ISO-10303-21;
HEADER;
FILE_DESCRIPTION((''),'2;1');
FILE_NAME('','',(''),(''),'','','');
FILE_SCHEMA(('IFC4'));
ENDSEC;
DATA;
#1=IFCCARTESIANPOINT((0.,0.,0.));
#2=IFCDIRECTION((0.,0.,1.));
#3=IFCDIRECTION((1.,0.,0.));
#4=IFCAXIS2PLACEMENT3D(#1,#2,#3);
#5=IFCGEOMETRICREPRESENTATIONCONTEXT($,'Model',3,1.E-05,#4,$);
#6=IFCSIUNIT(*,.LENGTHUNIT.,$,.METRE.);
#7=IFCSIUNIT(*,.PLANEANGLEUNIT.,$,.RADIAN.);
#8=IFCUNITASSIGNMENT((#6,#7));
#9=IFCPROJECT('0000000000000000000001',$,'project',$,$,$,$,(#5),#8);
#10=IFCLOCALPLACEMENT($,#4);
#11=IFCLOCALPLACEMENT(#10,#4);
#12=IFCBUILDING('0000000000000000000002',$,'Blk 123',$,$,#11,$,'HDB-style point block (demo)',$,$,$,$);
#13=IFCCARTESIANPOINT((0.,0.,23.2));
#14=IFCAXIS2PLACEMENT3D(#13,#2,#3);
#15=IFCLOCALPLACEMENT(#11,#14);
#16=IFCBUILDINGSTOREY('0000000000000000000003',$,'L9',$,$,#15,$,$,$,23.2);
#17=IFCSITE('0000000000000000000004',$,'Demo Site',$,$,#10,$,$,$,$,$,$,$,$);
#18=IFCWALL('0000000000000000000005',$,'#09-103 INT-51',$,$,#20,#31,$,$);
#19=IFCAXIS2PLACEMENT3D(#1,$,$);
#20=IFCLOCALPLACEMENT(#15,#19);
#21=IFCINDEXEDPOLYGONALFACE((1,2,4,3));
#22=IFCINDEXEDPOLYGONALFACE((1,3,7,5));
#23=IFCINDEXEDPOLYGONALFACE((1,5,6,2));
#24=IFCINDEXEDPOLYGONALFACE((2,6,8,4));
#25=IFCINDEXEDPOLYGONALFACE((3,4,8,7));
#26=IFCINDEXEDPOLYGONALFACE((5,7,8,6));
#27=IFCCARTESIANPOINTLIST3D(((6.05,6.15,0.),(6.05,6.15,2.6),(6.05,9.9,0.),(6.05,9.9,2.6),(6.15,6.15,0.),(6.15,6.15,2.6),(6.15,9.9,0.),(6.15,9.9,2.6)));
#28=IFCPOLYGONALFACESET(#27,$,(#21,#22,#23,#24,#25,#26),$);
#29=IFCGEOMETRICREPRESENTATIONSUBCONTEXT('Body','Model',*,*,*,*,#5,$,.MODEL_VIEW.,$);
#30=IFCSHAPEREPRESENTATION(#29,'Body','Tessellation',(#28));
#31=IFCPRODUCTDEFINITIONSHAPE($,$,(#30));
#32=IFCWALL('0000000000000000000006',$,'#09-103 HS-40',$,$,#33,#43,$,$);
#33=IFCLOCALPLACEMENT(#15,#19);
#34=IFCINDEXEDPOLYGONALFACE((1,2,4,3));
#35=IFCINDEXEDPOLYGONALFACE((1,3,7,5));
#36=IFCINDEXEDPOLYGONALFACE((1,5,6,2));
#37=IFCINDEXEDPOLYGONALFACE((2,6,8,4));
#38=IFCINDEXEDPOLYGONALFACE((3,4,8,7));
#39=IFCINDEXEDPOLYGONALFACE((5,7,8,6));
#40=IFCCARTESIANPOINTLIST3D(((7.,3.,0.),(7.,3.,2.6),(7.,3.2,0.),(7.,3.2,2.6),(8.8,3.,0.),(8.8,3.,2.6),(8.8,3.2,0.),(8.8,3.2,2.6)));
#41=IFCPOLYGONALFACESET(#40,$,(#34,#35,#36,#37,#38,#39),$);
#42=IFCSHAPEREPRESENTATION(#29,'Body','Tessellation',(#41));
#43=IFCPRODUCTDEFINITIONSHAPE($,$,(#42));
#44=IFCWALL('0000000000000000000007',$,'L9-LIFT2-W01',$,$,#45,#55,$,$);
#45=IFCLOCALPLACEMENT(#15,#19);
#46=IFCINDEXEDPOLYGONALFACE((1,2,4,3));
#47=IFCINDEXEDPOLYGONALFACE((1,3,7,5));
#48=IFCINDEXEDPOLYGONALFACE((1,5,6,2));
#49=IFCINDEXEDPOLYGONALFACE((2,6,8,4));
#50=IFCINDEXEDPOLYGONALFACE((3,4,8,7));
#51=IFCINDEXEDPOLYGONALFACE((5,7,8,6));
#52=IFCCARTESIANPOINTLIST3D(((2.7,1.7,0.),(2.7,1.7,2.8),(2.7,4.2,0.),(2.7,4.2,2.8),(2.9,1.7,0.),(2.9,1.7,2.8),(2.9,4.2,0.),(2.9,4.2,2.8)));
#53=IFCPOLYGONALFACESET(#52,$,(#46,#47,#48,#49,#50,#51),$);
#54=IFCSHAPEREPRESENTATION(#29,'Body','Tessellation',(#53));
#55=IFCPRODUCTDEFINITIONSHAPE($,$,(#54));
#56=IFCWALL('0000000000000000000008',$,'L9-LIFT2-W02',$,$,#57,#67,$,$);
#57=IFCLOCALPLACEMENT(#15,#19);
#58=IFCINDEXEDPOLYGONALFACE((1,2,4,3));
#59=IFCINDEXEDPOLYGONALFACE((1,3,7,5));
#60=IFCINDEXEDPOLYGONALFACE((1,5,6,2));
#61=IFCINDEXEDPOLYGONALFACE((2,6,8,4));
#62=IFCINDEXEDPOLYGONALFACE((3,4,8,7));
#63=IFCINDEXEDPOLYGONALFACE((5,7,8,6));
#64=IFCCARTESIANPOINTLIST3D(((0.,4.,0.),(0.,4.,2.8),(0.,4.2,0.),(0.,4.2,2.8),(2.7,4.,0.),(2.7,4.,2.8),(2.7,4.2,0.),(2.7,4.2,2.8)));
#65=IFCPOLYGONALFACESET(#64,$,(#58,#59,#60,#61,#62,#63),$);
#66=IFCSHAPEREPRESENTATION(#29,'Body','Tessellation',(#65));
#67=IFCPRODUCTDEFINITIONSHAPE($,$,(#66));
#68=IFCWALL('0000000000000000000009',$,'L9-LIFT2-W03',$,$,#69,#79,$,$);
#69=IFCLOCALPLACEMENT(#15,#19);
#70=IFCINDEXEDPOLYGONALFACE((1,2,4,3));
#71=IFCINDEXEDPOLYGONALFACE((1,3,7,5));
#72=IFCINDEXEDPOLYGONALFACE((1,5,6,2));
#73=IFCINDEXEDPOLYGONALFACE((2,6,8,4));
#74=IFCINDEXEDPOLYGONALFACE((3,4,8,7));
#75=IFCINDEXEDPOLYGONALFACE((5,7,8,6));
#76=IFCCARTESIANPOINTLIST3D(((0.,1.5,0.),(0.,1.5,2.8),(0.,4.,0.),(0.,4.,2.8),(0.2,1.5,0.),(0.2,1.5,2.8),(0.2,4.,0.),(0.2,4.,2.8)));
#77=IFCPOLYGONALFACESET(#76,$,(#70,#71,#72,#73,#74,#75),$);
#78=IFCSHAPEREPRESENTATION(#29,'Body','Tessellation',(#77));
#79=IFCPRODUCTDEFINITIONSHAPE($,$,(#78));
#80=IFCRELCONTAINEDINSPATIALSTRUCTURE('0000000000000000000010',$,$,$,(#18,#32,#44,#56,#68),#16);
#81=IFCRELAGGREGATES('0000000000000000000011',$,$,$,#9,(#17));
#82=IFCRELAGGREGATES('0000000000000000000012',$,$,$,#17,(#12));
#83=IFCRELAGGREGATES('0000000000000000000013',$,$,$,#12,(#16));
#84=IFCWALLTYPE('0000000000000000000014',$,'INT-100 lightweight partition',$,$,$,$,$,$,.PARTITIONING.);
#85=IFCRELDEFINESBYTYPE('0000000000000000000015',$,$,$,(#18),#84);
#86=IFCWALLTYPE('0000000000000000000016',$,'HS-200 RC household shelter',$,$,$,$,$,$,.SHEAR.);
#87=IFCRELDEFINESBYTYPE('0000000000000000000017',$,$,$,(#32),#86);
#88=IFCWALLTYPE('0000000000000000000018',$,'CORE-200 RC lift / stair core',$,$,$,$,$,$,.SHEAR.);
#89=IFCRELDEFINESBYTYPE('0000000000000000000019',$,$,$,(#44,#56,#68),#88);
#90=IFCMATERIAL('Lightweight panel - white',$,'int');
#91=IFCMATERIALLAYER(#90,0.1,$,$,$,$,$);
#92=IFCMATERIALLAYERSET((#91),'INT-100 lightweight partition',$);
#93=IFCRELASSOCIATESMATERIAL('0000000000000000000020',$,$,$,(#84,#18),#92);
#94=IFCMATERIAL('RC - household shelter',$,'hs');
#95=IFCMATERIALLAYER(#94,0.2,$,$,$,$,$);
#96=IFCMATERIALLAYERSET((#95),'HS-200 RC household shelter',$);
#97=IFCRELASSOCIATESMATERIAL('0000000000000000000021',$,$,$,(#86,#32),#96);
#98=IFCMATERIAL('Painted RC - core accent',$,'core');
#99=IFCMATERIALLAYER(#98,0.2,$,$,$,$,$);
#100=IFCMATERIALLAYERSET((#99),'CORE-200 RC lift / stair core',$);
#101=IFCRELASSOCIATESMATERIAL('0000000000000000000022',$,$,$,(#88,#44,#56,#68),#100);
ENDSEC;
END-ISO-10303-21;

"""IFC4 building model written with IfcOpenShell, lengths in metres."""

from ifc_helpers import new_model, si_unit, frame, origin_with_axes, place, context, subcontext, project, spatial, indexed_curve, outline, extrude, material, layer, layer_set, layer_usage, type_object, element, save


model = new_model("IFC4")

# Units and contexts
model_context = context("Model", 3, precision=1e-05, world=origin_with_axes())
body_context = subcontext(model_context, "Body", "Model", "MODEL_VIEW")
ifc_project = project(units=[si_unit("LENGTHUNIT", "METRE"), si_unit("PLANEANGLEUNIT", "RADIAN")], contexts=[model_context])

# Site, building, storey
site_placement = place(None, origin_with_axes())
site = spatial("IfcSite", under=ifc_project, at=site_placement, Name="Demo Site")
building_placement = place(site_placement, origin_with_axes())
building = spatial("IfcBuilding", under=site, at=building_placement, Name="Blk 123", LongName="HDB-style point block (demo)")
storey_placement = place(building_placement, frame((0.0, 0.0, 23.2), z_axis=(0.0, 0.0, 1.0), x_axis=(1.0, 0.0, 0.0)))
storey = spatial("IfcBuildingStorey", under=building, at=storey_placement, Name="L9", Elevation=23.2)

# Shared definitions
ifc_material_1 = material(Name="Lightweight panel - white", Category="int")
ifc_layer_1 = layer(ifc_material_1, 0.1)
ifc_layer_set_1 = layer_set([ifc_layer_1], Name="INT-100 lightweight partition")
ifc_layer_usage_1 = layer_usage(ifc_layer_set_1, "AXIS2", "POSITIVE", -0.05)
wall_type_1 = type_object("IfcWallType", Name="INT-100 lightweight partition", PredefinedType="PARTITIONING", material=ifc_layer_set_1)

# Walls
wall_1_placement = place(storey_placement, frame((6.1, 6.15, 0.0), z_axis=(0.0, 0.0, 1.0), x_axis=(0.0, 1.0, 0.0)))
element("IfcWall", 1, at=wall_1_placement, inside=storey, type_object=wall_type_1, material=ifc_layer_usage_1, Name="#09-103 INT-51", context=body_context, shape_type="SweptSolid", body=[
    extrude(outline(indexed_curve([(0.0, 0.0), (0.0, 0.1), (3.75, 0.1), (3.75, 0.0), (0.0, 0.0)], self_intersect=False)), frame((0.0, -0.05, 0.0), z_axis=(0.0, 0.0, 1.0), x_axis=(1.0, 0.0, 0.0)), (0.0, 0.0, 1.0), 2.6),
])
ifc_material_2 = material(Name="RC - household shelter", Category="hs")
ifc_layer_2 = layer(ifc_material_2, 0.2)
ifc_layer_set_2 = layer_set([ifc_layer_2], Name="HS-200 RC household shelter")
ifc_layer_usage_2 = layer_usage(ifc_layer_set_2, "AXIS2", "POSITIVE", -0.1)
wall_type_2 = type_object("IfcWallType", Name="HS-200 RC household shelter", PredefinedType="SHEAR", material=ifc_layer_set_2)
wall_2_placement = place(storey_placement, frame((7.0, 3.1, 0.0), z_axis=(0.0, 0.0, 1.0), x_axis=(1.0, 0.0, 0.0)))
element("IfcWall", 2, at=wall_2_placement, inside=storey, type_object=wall_type_2, material=ifc_layer_usage_2, Name="#09-103 HS-40", context=body_context, shape_type="SweptSolid", body=[
    extrude(outline(indexed_curve([(0.0, 0.0), (0.0, 0.2), (1.8, 0.2), (1.8, 0.0), (0.0, 0.0)], self_intersect=False)), frame((0.0, -0.1, 0.0), z_axis=(0.0, 0.0, 1.0), x_axis=(1.0, 0.0, 0.0)), (0.0, 0.0, 1.0), 2.6),
])
ifc_material_3 = material(Name="Painted RC - core accent", Category="core")
ifc_layer_3 = layer(ifc_material_3, 0.2)
ifc_layer_set_3 = layer_set([ifc_layer_3], Name="CORE-200 RC lift / stair core")
ifc_layer_usage_3 = layer_usage(ifc_layer_set_3, "AXIS2", "POSITIVE", 0.0)
wall_type_3 = type_object("IfcWallType", Name="CORE-200 RC lift / stair core", PredefinedType="SHEAR", material=ifc_layer_set_3)
wall_3_placement = place(storey_placement, frame((2.9, 1.7, 0.0), z_axis=(0.0, 0.0, 1.0), x_axis=(0.0, 1.0, 0.0)))
element("IfcWall", 3, at=wall_3_placement, inside=storey, type_object=wall_type_3, material=ifc_layer_usage_3, Name="L9-LIFT2-W01", context=body_context, shape_type="SweptSolid", body=[
    extrude(outline(indexed_curve([(0.0, 0.0), (0.0, 0.2), (2.5, 0.2), (2.5, 0.0), (0.0, 0.0)], self_intersect=False)), origin_with_axes(), (0.0, 0.0, 1.0), 2.8),
])
wall_4_placement = place(storey_placement, frame((2.7, 4.2, 0.0), z_axis=(0.0, 0.0, 1.0), x_axis=(-1.0, 0.0, 0.0)))
element("IfcWall", 4, at=wall_4_placement, inside=storey, type_object=wall_type_3, material=ifc_layer_usage_3, Name="L9-LIFT2-W02", context=body_context, shape_type="SweptSolid", body=[
    extrude(outline(indexed_curve([(0.0, 0.0), (0.0, 0.2), (2.7, 0.2), (2.7, 0.0), (0.0, 0.0)], self_intersect=False)), origin_with_axes(), (0.0, 0.0, 1.0), 2.8),
])
wall_5_placement = place(storey_placement, frame((0.0, 4.0, 0.0), z_axis=(0.0, 0.0, 1.0), x_axis=(0.0, -1.0, 0.0)))
element("IfcWall", 5, at=wall_5_placement, inside=storey, type_object=wall_type_3, material=ifc_layer_usage_3, Name="L9-LIFT2-W03", context=body_context, shape_type="SweptSolid", body=[
    extrude(outline(indexed_curve([(0.0, 0.0), (0.0, 0.2), (2.5, 0.2), (2.5, 0.0), (0.0, 0.0)], self_intersect=False)), origin_with_axes(), (0.0, 0.0, 1.0), 2.8),
])

save(model, "model.ifc")
